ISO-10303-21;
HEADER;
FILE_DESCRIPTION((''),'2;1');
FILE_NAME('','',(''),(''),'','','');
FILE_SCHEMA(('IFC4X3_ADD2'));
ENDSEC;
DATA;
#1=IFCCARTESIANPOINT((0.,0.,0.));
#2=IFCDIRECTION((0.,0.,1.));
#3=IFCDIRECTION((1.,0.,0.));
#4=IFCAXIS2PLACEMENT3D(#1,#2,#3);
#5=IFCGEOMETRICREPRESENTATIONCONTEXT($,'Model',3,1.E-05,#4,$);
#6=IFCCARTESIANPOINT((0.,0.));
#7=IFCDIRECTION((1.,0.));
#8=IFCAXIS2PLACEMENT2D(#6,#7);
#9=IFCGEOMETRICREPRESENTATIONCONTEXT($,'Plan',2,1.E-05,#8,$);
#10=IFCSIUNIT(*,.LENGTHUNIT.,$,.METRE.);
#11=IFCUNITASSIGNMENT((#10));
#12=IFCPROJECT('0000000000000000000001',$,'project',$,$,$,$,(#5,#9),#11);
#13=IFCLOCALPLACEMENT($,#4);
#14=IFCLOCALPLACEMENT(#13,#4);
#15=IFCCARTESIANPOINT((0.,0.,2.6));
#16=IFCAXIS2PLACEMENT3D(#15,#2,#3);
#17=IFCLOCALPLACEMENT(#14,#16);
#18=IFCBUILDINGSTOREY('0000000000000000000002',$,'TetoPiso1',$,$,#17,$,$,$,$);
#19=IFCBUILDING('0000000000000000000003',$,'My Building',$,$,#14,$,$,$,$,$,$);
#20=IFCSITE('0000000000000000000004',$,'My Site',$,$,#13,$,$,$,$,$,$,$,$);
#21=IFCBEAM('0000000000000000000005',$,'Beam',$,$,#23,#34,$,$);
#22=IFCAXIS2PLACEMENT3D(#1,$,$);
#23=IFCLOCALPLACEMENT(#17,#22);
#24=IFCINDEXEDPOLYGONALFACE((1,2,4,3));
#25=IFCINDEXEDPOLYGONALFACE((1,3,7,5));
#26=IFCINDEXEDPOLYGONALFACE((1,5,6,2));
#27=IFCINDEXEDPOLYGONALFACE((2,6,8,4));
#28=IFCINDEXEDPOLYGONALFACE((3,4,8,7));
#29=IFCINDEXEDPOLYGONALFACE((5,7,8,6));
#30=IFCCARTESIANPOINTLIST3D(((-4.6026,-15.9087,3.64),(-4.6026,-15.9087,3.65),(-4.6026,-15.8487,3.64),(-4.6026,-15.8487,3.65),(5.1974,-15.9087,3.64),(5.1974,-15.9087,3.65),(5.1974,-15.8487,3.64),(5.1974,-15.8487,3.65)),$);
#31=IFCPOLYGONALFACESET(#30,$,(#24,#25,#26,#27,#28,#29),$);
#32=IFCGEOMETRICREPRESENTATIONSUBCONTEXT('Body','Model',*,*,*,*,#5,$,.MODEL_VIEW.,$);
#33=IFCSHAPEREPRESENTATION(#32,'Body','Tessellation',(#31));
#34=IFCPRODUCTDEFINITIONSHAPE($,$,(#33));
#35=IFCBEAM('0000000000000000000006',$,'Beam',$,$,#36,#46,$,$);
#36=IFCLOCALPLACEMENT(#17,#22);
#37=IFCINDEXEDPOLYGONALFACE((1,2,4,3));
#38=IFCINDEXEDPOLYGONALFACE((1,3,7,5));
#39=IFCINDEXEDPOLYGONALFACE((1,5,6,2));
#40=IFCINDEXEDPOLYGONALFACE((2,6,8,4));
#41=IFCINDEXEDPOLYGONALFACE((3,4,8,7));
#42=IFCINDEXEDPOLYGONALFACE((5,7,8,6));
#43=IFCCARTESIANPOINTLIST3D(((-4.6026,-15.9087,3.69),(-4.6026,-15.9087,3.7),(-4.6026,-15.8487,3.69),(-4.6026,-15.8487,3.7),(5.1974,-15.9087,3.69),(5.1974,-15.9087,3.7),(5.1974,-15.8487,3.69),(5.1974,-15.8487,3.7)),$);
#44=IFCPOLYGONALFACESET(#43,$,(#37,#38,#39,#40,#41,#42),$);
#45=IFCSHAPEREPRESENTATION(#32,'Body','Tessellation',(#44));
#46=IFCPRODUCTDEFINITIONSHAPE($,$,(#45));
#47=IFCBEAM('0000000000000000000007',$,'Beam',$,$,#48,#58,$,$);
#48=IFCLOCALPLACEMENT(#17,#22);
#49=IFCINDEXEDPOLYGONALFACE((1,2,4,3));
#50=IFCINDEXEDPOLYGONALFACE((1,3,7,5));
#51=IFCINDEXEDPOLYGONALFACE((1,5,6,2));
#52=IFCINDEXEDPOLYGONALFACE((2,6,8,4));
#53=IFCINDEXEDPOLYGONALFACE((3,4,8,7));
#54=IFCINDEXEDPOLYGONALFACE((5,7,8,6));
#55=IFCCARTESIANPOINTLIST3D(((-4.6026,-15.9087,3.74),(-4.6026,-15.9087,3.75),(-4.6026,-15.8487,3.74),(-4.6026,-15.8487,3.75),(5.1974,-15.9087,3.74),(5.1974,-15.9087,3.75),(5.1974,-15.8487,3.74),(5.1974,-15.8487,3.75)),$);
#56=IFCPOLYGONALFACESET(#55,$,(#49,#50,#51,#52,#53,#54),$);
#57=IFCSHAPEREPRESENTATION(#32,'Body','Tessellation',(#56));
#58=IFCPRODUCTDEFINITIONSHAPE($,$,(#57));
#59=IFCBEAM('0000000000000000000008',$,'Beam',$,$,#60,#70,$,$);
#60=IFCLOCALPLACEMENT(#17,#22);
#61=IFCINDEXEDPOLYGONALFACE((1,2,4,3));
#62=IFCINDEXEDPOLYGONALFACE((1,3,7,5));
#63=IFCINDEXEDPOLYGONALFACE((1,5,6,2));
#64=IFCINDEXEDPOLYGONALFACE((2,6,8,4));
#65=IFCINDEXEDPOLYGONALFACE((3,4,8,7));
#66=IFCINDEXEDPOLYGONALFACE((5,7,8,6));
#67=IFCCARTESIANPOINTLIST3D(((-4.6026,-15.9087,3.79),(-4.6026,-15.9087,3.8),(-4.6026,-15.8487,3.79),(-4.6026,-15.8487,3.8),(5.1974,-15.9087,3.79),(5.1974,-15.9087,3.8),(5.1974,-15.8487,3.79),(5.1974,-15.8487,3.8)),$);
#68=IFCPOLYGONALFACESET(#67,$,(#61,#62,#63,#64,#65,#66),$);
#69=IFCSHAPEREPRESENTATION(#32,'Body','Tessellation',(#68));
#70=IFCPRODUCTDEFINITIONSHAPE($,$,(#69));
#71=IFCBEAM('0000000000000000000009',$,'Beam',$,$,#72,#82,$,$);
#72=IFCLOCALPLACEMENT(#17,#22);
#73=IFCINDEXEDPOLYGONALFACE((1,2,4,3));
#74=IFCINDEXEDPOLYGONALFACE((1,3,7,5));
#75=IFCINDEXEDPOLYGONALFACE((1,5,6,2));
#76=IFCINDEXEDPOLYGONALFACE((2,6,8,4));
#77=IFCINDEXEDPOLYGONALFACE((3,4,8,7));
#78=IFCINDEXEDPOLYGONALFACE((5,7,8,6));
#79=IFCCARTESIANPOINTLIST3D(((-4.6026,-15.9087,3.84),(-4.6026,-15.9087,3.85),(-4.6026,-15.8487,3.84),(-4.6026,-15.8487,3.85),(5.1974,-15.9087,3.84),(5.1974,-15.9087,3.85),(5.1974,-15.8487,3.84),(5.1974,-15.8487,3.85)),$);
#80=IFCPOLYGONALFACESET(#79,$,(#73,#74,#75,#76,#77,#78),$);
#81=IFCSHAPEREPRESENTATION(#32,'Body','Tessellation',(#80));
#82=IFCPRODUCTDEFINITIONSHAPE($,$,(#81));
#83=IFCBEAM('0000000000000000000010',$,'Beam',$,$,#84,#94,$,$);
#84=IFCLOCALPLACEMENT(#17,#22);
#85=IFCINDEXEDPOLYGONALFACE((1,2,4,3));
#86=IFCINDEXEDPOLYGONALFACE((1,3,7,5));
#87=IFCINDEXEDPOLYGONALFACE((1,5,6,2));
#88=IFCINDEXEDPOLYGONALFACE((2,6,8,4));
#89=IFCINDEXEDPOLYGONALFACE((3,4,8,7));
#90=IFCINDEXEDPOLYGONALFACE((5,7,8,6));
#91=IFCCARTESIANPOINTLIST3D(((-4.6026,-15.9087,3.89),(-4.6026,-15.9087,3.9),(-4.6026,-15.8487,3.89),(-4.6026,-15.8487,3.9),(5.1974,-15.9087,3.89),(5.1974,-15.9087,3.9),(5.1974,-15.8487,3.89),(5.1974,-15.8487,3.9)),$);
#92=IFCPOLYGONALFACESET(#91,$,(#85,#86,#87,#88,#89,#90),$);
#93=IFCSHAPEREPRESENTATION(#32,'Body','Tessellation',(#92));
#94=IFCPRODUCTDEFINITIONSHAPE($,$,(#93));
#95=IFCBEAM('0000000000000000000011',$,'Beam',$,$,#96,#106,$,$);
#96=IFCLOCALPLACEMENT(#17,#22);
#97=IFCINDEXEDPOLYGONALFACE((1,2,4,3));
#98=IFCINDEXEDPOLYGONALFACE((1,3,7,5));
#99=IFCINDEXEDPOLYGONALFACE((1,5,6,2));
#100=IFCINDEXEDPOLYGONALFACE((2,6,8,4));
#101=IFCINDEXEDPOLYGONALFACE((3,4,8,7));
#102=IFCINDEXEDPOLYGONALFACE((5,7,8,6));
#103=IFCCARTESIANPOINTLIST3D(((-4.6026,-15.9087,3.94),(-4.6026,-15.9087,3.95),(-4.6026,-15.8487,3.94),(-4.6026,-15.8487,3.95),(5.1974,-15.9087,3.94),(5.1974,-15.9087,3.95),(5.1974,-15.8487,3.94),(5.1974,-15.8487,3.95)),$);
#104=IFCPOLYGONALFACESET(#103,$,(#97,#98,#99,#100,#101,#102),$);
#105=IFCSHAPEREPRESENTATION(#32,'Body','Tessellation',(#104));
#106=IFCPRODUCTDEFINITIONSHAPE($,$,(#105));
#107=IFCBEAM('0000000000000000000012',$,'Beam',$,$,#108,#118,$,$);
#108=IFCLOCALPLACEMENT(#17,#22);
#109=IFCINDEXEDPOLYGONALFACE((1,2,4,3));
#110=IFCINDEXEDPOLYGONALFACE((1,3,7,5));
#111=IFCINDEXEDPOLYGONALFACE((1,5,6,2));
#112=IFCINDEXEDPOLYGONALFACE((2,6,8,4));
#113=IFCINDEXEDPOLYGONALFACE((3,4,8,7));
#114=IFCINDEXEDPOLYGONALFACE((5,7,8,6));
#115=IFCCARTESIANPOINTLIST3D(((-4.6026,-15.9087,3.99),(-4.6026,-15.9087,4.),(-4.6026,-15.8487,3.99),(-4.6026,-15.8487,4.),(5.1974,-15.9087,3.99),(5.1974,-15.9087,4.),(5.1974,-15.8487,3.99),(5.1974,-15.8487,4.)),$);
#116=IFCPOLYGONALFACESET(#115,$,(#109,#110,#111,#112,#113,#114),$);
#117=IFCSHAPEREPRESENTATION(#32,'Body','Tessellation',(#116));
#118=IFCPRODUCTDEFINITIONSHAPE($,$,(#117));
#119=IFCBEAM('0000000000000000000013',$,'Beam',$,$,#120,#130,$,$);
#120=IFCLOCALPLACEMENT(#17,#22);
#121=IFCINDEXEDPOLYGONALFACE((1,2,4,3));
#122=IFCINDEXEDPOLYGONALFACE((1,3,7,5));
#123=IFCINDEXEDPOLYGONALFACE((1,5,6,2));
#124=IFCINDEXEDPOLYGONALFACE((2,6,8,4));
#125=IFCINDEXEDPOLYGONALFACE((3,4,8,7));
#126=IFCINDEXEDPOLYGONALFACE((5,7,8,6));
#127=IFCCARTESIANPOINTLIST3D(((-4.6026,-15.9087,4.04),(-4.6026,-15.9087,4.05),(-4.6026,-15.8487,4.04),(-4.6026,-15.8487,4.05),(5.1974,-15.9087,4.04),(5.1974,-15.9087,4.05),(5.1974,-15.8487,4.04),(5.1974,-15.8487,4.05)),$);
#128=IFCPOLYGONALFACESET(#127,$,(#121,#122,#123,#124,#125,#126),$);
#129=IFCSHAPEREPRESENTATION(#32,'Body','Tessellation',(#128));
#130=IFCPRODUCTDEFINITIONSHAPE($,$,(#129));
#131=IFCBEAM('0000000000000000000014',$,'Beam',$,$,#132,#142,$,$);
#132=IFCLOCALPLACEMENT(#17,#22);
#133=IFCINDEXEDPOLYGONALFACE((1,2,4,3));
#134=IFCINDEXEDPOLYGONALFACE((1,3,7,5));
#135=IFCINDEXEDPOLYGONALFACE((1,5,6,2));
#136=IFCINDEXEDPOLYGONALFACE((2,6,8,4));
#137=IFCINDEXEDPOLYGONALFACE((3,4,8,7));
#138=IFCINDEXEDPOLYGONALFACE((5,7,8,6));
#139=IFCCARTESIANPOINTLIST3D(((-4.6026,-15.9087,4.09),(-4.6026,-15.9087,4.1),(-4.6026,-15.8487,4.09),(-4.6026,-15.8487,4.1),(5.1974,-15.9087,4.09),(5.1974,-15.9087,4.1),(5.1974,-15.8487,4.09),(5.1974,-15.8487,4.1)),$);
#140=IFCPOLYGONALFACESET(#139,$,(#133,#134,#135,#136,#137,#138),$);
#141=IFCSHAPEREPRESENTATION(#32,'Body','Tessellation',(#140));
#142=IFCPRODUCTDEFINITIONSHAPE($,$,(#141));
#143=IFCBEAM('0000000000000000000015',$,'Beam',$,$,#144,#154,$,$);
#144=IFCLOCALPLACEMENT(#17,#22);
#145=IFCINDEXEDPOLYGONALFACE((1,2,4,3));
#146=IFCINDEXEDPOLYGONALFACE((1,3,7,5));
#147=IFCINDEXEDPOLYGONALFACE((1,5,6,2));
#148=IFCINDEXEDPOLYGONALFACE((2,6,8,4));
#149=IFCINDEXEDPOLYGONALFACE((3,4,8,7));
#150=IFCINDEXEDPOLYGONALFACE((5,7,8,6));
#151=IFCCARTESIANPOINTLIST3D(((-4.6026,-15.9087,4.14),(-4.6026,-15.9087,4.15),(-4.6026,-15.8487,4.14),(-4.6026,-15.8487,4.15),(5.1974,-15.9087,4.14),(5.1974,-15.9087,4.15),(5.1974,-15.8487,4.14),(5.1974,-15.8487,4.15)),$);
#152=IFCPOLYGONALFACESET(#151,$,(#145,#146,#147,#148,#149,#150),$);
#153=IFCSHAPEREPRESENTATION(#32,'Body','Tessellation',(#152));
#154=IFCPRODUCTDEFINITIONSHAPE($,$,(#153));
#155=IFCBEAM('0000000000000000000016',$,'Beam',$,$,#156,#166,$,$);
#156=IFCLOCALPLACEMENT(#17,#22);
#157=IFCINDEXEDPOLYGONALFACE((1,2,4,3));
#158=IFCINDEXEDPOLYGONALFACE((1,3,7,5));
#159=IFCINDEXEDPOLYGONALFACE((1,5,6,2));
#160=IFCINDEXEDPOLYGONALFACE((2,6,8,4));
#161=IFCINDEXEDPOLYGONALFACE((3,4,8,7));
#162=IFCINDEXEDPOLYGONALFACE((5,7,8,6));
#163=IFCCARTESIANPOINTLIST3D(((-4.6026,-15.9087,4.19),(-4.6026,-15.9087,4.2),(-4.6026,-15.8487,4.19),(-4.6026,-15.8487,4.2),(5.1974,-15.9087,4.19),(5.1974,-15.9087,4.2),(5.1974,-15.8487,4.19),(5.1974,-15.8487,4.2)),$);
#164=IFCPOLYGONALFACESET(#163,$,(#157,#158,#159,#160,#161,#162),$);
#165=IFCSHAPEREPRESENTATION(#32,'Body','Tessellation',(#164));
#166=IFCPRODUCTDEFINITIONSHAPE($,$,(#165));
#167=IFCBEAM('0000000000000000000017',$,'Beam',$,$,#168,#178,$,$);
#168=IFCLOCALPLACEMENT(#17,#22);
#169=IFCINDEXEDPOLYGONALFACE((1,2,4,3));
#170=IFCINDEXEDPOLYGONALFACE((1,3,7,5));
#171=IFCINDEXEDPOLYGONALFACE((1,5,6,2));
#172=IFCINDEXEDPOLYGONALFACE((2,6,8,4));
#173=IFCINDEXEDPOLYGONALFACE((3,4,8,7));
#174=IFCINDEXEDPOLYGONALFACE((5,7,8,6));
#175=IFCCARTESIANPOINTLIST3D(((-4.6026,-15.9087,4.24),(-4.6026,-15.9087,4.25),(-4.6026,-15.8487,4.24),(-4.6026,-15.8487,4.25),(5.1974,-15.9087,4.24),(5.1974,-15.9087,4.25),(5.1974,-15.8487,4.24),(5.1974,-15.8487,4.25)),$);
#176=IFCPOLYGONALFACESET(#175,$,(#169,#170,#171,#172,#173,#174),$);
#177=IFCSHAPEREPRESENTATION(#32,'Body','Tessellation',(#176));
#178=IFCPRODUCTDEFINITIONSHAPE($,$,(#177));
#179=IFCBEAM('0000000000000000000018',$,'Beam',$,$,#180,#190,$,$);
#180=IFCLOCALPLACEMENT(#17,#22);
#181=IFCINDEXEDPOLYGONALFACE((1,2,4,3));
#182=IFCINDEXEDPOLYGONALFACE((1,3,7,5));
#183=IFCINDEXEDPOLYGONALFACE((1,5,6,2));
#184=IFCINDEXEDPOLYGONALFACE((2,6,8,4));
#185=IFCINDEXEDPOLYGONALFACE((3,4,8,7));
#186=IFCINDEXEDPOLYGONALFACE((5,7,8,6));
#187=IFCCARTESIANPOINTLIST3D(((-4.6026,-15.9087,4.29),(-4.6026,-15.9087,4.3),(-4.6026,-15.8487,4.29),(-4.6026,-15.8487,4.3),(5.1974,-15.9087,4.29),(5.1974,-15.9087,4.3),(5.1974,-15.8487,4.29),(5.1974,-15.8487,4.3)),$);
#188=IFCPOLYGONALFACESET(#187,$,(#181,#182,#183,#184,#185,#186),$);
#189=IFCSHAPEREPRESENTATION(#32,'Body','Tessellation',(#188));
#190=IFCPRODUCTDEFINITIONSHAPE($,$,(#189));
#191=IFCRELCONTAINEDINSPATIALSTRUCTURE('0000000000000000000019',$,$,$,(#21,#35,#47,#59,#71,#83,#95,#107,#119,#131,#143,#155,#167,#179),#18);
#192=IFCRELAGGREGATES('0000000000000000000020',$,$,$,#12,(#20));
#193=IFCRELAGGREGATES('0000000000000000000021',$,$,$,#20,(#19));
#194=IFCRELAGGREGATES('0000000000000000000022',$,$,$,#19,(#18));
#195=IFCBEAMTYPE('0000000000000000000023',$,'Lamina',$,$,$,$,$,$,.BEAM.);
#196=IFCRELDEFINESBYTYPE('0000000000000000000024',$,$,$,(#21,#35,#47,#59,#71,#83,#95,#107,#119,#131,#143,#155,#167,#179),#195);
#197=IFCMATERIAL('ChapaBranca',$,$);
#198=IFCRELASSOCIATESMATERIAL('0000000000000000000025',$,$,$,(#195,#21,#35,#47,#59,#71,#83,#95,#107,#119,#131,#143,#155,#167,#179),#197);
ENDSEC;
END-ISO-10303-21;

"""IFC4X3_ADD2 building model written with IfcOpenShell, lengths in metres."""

from ifc_helpers import new_model, si_unit, frame, origin_with_axes, origin_2d, origin_2d_with_axis, place, context, subcontext, project, spatial, rectangle, extrude, material, material_profile, profile_set, profile_usage, type_object, element, save


model = new_model("IFC4X3_ADD2")

# Units and contexts
model_context = context("Model", 3, precision=1e-05, world=origin_with_axes())
plan_context = context("Plan", 2, precision=1e-05, world=origin_2d_with_axis())
body_context = subcontext(model_context, "Body", "Model", "MODEL_VIEW")
ifc_project = project(units=[si_unit("LENGTHUNIT", "METRE")], contexts=[model_context, plan_context])

# Site, building, storey
site_placement = place(None, origin_with_axes())
site = spatial("IfcSite", under=ifc_project, at=site_placement, Name="My Site")
building_placement = place(site_placement, origin_with_axes())
building = spatial("IfcBuilding", under=site, at=building_placement, Name="My Building")
storey_placement = place(building_placement, frame((0.0, 0.0, 2.6), z_axis=(0.0, 0.0, 1.0), x_axis=(1.0, 0.0, 0.0)))
storey = spatial("IfcBuildingStorey", under=building, at=storey_placement, Name="TetoPiso1")

# Beams
ifc_material = material(Name="ChapaBranca")
ifc_material_profile = material_profile(ifc_material, rectangle(XDim=0.06, YDim=0.01, at=origin_2d()))
ifc_profile_set = profile_set([ifc_material_profile])
beam_type = type_object("IfcBeamType", Name="Lamina", PredefinedType="BEAM", material=ifc_profile_set)
ifc_profile_usage_1 = profile_usage(ifc_profile_set, cardinal=5)
beam_1_placement = place(storey_placement, frame((-4.6026, -15.8787, 3.645), z_axis=(1.0, 0.0, 0.0), x_axis=(0.0, 1.0, 0.0)))
element("IfcBeam", 1, at=beam_1_placement, inside=storey, type_object=beam_type, material=ifc_profile_usage_1, Name="Beam", context=body_context, shape_type="SweptSolid", body=[
    extrude(rectangle(XDim=0.06, YDim=0.01, at=origin_2d()), origin_with_axes(), (0.0, 0.0, 1.0), 9.8),
])
ifc_profile_usage_2 = profile_usage(ifc_profile_set, cardinal=5)
beam_2_placement = place(storey_placement, frame((-4.6026, -15.8787, 3.695), z_axis=(1.0, 0.0, 0.0), x_axis=(0.0, 1.0, 0.0)))
element("IfcBeam", 2, at=beam_2_placement, inside=storey, type_object=beam_type, material=ifc_profile_usage_2, Name="Beam", context=body_context, shape_type="SweptSolid", body=[
    extrude(rectangle(XDim=0.06, YDim=0.01, at=origin_2d()), origin_with_axes(), (0.0, 0.0, 1.0), 9.8),
])
ifc_profile_usage_3 = profile_usage(ifc_profile_set, cardinal=5)
beam_3_placement = place(storey_placement, frame((-4.6026, -15.8787, 3.745), z_axis=(1.0, 0.0, 0.0), x_axis=(0.0, 1.0, 0.0)))
element("IfcBeam", 3, at=beam_3_placement, inside=storey, type_object=beam_type, material=ifc_profile_usage_3, Name="Beam", context=body_context, shape_type="SweptSolid", body=[
    extrude(rectangle(XDim=0.06, YDim=0.01, at=origin_2d()), origin_with_axes(), (0.0, 0.0, 1.0), 9.8),
])
ifc_profile_usage_4 = profile_usage(ifc_profile_set, cardinal=5)
beam_4_placement = place(storey_placement, frame((-4.6026, -15.8787, 3.795), z_axis=(1.0, 0.0, 0.0), x_axis=(0.0, 1.0, 0.0)))
element("IfcBeam", 4, at=beam_4_placement, inside=storey, type_object=beam_type, material=ifc_profile_usage_4, Name="Beam", context=body_context, shape_type="SweptSolid", body=[
    extrude(rectangle(XDim=0.06, YDim=0.01, at=origin_2d()), origin_with_axes(), (0.0, 0.0, 1.0), 9.8),
])
ifc_profile_usage_5 = profile_usage(ifc_profile_set, cardinal=5)
beam_5_placement = place(storey_placement, frame((-4.6026, -15.8787, 3.845), z_axis=(1.0, 0.0, 0.0), x_axis=(0.0, 1.0, 0.0)))
element("IfcBeam", 5, at=beam_5_placement, inside=storey, type_object=beam_type, material=ifc_profile_usage_5, Name="Beam", context=body_context, shape_type="SweptSolid", body=[
    extrude(rectangle(XDim=0.06, YDim=0.01, at=origin_2d()), origin_with_axes(), (0.0, 0.0, 1.0), 9.8),
])
ifc_profile_usage_6 = profile_usage(ifc_profile_set, cardinal=5)
beam_6_placement = place(storey_placement, frame((-4.6026, -15.8787, 3.895), z_axis=(1.0, 0.0, 0.0), x_axis=(0.0, 1.0, 0.0)))
element("IfcBeam", 6, at=beam_6_placement, inside=storey, type_object=beam_type, material=ifc_profile_usage_6, Name="Beam", context=body_context, shape_type="SweptSolid", body=[
    extrude(rectangle(XDim=0.06, YDim=0.01, at=origin_2d()), origin_with_axes(), (0.0, 0.0, 1.0), 9.8),
])
ifc_profile_usage_7 = profile_usage(ifc_profile_set, cardinal=5)
beam_7_placement = place(storey_placement, frame((-4.6026, -15.8787, 3.945), z_axis=(1.0, 0.0, 0.0), x_axis=(0.0, 1.0, 0.0)))
element("IfcBeam", 7, at=beam_7_placement, inside=storey, type_object=beam_type, material=ifc_profile_usage_7, Name="Beam", context=body_context, shape_type="SweptSolid", body=[
    extrude(rectangle(XDim=0.06, YDim=0.01, at=origin_2d()), origin_with_axes(), (0.0, 0.0, 1.0), 9.8),
])
ifc_profile_usage_8 = profile_usage(ifc_profile_set, cardinal=5)
beam_8_placement = place(storey_placement, frame((-4.6026, -15.8787, 3.995), z_axis=(1.0, 0.0, 0.0), x_axis=(0.0, 1.0, 0.0)))
element("IfcBeam", 8, at=beam_8_placement, inside=storey, type_object=beam_type, material=ifc_profile_usage_8, Name="Beam", context=body_context, shape_type="SweptSolid", body=[
    extrude(rectangle(XDim=0.06, YDim=0.01, at=origin_2d()), origin_with_axes(), (0.0, 0.0, 1.0), 9.8),
])
ifc_profile_usage_9 = profile_usage(ifc_profile_set, cardinal=5)
beam_9_placement = place(storey_placement, frame((-4.6026, -15.8787, 4.045), z_axis=(1.0, 0.0, 0.0), x_axis=(0.0, 1.0, 0.0)))
element("IfcBeam", 9, at=beam_9_placement, inside=storey, type_object=beam_type, material=ifc_profile_usage_9, Name="Beam", context=body_context, shape_type="SweptSolid", body=[
    extrude(rectangle(XDim=0.06, YDim=0.01, at=origin_2d()), origin_with_axes(), (0.0, 0.0, 1.0), 9.8),
])
ifc_profile_usage_10 = profile_usage(ifc_profile_set, cardinal=5)
beam_10_placement = place(storey_placement, frame((-4.6026, -15.8787, 4.095), z_axis=(1.0, 0.0, 0.0), x_axis=(0.0, 1.0, 0.0)))
element("IfcBeam", 10, at=beam_10_placement, inside=storey, type_object=beam_type, material=ifc_profile_usage_10, Name="Beam", context=body_context, shape_type="SweptSolid", body=[
    extrude(rectangle(XDim=0.06, YDim=0.01, at=origin_2d()), origin_with_axes(), (0.0, 0.0, 1.0), 9.8),
])
ifc_profile_usage_11 = profile_usage(ifc_profile_set, cardinal=5)
beam_11_placement = place(storey_placement, frame((-4.6026, -15.8787, 4.145), z_axis=(1.0, 0.0, 0.0), x_axis=(0.0, 1.0, 0.0)))
element("IfcBeam", 11, at=beam_11_placement, inside=storey, type_object=beam_type, material=ifc_profile_usage_11, Name="Beam", context=body_context, shape_type="SweptSolid", body=[
    extrude(rectangle(XDim=0.06, YDim=0.01, at=origin_2d()), origin_with_axes(), (0.0, 0.0, 1.0), 9.8),
])
ifc_profile_usage_12 = profile_usage(ifc_profile_set, cardinal=5)
beam_12_placement = place(storey_placement, frame((-4.6026, -15.8787, 4.195), z_axis=(1.0, 0.0, 0.0), x_axis=(0.0, 1.0, 0.0)))
element("IfcBeam", 12, at=beam_12_placement, inside=storey, type_object=beam_type, material=ifc_profile_usage_12, Name="Beam", context=body_context, shape_type="SweptSolid", body=[
    extrude(rectangle(XDim=0.06, YDim=0.01, at=origin_2d()), origin_with_axes(), (0.0, 0.0, 1.0), 9.8),
])
ifc_profile_usage_13 = profile_usage(ifc_profile_set, cardinal=5)
beam_13_placement = place(storey_placement, frame((-4.6026, -15.8787, 4.245), z_axis=(1.0, 0.0, 0.0), x_axis=(0.0, 1.0, 0.0)))
element("IfcBeam", 13, at=beam_13_placement, inside=storey, type_object=beam_type, material=ifc_profile_usage_13, Name="Beam", context=body_context, shape_type="SweptSolid", body=[
    extrude(rectangle(XDim=0.06, YDim=0.01, at=origin_2d()), origin_with_axes(), (0.0, 0.0, 1.0), 9.8),
])
ifc_profile_usage_14 = profile_usage(ifc_profile_set, cardinal=5)
beam_14_placement = place(storey_placement, frame((-4.6026, -15.8787, 4.295), z_axis=(1.0, 0.0, 0.0), x_axis=(0.0, 1.0, 0.0)))
element("IfcBeam", 14, at=beam_14_placement, inside=storey, type_object=beam_type, material=ifc_profile_usage_14, Name="Beam", context=body_context, shape_type="SweptSolid", body=[
    extrude(rectangle(XDim=0.06, YDim=0.01, at=origin_2d()), origin_with_axes(), (0.0, 0.0, 1.0), 9.8),
])

save(model, "model.ifc")
